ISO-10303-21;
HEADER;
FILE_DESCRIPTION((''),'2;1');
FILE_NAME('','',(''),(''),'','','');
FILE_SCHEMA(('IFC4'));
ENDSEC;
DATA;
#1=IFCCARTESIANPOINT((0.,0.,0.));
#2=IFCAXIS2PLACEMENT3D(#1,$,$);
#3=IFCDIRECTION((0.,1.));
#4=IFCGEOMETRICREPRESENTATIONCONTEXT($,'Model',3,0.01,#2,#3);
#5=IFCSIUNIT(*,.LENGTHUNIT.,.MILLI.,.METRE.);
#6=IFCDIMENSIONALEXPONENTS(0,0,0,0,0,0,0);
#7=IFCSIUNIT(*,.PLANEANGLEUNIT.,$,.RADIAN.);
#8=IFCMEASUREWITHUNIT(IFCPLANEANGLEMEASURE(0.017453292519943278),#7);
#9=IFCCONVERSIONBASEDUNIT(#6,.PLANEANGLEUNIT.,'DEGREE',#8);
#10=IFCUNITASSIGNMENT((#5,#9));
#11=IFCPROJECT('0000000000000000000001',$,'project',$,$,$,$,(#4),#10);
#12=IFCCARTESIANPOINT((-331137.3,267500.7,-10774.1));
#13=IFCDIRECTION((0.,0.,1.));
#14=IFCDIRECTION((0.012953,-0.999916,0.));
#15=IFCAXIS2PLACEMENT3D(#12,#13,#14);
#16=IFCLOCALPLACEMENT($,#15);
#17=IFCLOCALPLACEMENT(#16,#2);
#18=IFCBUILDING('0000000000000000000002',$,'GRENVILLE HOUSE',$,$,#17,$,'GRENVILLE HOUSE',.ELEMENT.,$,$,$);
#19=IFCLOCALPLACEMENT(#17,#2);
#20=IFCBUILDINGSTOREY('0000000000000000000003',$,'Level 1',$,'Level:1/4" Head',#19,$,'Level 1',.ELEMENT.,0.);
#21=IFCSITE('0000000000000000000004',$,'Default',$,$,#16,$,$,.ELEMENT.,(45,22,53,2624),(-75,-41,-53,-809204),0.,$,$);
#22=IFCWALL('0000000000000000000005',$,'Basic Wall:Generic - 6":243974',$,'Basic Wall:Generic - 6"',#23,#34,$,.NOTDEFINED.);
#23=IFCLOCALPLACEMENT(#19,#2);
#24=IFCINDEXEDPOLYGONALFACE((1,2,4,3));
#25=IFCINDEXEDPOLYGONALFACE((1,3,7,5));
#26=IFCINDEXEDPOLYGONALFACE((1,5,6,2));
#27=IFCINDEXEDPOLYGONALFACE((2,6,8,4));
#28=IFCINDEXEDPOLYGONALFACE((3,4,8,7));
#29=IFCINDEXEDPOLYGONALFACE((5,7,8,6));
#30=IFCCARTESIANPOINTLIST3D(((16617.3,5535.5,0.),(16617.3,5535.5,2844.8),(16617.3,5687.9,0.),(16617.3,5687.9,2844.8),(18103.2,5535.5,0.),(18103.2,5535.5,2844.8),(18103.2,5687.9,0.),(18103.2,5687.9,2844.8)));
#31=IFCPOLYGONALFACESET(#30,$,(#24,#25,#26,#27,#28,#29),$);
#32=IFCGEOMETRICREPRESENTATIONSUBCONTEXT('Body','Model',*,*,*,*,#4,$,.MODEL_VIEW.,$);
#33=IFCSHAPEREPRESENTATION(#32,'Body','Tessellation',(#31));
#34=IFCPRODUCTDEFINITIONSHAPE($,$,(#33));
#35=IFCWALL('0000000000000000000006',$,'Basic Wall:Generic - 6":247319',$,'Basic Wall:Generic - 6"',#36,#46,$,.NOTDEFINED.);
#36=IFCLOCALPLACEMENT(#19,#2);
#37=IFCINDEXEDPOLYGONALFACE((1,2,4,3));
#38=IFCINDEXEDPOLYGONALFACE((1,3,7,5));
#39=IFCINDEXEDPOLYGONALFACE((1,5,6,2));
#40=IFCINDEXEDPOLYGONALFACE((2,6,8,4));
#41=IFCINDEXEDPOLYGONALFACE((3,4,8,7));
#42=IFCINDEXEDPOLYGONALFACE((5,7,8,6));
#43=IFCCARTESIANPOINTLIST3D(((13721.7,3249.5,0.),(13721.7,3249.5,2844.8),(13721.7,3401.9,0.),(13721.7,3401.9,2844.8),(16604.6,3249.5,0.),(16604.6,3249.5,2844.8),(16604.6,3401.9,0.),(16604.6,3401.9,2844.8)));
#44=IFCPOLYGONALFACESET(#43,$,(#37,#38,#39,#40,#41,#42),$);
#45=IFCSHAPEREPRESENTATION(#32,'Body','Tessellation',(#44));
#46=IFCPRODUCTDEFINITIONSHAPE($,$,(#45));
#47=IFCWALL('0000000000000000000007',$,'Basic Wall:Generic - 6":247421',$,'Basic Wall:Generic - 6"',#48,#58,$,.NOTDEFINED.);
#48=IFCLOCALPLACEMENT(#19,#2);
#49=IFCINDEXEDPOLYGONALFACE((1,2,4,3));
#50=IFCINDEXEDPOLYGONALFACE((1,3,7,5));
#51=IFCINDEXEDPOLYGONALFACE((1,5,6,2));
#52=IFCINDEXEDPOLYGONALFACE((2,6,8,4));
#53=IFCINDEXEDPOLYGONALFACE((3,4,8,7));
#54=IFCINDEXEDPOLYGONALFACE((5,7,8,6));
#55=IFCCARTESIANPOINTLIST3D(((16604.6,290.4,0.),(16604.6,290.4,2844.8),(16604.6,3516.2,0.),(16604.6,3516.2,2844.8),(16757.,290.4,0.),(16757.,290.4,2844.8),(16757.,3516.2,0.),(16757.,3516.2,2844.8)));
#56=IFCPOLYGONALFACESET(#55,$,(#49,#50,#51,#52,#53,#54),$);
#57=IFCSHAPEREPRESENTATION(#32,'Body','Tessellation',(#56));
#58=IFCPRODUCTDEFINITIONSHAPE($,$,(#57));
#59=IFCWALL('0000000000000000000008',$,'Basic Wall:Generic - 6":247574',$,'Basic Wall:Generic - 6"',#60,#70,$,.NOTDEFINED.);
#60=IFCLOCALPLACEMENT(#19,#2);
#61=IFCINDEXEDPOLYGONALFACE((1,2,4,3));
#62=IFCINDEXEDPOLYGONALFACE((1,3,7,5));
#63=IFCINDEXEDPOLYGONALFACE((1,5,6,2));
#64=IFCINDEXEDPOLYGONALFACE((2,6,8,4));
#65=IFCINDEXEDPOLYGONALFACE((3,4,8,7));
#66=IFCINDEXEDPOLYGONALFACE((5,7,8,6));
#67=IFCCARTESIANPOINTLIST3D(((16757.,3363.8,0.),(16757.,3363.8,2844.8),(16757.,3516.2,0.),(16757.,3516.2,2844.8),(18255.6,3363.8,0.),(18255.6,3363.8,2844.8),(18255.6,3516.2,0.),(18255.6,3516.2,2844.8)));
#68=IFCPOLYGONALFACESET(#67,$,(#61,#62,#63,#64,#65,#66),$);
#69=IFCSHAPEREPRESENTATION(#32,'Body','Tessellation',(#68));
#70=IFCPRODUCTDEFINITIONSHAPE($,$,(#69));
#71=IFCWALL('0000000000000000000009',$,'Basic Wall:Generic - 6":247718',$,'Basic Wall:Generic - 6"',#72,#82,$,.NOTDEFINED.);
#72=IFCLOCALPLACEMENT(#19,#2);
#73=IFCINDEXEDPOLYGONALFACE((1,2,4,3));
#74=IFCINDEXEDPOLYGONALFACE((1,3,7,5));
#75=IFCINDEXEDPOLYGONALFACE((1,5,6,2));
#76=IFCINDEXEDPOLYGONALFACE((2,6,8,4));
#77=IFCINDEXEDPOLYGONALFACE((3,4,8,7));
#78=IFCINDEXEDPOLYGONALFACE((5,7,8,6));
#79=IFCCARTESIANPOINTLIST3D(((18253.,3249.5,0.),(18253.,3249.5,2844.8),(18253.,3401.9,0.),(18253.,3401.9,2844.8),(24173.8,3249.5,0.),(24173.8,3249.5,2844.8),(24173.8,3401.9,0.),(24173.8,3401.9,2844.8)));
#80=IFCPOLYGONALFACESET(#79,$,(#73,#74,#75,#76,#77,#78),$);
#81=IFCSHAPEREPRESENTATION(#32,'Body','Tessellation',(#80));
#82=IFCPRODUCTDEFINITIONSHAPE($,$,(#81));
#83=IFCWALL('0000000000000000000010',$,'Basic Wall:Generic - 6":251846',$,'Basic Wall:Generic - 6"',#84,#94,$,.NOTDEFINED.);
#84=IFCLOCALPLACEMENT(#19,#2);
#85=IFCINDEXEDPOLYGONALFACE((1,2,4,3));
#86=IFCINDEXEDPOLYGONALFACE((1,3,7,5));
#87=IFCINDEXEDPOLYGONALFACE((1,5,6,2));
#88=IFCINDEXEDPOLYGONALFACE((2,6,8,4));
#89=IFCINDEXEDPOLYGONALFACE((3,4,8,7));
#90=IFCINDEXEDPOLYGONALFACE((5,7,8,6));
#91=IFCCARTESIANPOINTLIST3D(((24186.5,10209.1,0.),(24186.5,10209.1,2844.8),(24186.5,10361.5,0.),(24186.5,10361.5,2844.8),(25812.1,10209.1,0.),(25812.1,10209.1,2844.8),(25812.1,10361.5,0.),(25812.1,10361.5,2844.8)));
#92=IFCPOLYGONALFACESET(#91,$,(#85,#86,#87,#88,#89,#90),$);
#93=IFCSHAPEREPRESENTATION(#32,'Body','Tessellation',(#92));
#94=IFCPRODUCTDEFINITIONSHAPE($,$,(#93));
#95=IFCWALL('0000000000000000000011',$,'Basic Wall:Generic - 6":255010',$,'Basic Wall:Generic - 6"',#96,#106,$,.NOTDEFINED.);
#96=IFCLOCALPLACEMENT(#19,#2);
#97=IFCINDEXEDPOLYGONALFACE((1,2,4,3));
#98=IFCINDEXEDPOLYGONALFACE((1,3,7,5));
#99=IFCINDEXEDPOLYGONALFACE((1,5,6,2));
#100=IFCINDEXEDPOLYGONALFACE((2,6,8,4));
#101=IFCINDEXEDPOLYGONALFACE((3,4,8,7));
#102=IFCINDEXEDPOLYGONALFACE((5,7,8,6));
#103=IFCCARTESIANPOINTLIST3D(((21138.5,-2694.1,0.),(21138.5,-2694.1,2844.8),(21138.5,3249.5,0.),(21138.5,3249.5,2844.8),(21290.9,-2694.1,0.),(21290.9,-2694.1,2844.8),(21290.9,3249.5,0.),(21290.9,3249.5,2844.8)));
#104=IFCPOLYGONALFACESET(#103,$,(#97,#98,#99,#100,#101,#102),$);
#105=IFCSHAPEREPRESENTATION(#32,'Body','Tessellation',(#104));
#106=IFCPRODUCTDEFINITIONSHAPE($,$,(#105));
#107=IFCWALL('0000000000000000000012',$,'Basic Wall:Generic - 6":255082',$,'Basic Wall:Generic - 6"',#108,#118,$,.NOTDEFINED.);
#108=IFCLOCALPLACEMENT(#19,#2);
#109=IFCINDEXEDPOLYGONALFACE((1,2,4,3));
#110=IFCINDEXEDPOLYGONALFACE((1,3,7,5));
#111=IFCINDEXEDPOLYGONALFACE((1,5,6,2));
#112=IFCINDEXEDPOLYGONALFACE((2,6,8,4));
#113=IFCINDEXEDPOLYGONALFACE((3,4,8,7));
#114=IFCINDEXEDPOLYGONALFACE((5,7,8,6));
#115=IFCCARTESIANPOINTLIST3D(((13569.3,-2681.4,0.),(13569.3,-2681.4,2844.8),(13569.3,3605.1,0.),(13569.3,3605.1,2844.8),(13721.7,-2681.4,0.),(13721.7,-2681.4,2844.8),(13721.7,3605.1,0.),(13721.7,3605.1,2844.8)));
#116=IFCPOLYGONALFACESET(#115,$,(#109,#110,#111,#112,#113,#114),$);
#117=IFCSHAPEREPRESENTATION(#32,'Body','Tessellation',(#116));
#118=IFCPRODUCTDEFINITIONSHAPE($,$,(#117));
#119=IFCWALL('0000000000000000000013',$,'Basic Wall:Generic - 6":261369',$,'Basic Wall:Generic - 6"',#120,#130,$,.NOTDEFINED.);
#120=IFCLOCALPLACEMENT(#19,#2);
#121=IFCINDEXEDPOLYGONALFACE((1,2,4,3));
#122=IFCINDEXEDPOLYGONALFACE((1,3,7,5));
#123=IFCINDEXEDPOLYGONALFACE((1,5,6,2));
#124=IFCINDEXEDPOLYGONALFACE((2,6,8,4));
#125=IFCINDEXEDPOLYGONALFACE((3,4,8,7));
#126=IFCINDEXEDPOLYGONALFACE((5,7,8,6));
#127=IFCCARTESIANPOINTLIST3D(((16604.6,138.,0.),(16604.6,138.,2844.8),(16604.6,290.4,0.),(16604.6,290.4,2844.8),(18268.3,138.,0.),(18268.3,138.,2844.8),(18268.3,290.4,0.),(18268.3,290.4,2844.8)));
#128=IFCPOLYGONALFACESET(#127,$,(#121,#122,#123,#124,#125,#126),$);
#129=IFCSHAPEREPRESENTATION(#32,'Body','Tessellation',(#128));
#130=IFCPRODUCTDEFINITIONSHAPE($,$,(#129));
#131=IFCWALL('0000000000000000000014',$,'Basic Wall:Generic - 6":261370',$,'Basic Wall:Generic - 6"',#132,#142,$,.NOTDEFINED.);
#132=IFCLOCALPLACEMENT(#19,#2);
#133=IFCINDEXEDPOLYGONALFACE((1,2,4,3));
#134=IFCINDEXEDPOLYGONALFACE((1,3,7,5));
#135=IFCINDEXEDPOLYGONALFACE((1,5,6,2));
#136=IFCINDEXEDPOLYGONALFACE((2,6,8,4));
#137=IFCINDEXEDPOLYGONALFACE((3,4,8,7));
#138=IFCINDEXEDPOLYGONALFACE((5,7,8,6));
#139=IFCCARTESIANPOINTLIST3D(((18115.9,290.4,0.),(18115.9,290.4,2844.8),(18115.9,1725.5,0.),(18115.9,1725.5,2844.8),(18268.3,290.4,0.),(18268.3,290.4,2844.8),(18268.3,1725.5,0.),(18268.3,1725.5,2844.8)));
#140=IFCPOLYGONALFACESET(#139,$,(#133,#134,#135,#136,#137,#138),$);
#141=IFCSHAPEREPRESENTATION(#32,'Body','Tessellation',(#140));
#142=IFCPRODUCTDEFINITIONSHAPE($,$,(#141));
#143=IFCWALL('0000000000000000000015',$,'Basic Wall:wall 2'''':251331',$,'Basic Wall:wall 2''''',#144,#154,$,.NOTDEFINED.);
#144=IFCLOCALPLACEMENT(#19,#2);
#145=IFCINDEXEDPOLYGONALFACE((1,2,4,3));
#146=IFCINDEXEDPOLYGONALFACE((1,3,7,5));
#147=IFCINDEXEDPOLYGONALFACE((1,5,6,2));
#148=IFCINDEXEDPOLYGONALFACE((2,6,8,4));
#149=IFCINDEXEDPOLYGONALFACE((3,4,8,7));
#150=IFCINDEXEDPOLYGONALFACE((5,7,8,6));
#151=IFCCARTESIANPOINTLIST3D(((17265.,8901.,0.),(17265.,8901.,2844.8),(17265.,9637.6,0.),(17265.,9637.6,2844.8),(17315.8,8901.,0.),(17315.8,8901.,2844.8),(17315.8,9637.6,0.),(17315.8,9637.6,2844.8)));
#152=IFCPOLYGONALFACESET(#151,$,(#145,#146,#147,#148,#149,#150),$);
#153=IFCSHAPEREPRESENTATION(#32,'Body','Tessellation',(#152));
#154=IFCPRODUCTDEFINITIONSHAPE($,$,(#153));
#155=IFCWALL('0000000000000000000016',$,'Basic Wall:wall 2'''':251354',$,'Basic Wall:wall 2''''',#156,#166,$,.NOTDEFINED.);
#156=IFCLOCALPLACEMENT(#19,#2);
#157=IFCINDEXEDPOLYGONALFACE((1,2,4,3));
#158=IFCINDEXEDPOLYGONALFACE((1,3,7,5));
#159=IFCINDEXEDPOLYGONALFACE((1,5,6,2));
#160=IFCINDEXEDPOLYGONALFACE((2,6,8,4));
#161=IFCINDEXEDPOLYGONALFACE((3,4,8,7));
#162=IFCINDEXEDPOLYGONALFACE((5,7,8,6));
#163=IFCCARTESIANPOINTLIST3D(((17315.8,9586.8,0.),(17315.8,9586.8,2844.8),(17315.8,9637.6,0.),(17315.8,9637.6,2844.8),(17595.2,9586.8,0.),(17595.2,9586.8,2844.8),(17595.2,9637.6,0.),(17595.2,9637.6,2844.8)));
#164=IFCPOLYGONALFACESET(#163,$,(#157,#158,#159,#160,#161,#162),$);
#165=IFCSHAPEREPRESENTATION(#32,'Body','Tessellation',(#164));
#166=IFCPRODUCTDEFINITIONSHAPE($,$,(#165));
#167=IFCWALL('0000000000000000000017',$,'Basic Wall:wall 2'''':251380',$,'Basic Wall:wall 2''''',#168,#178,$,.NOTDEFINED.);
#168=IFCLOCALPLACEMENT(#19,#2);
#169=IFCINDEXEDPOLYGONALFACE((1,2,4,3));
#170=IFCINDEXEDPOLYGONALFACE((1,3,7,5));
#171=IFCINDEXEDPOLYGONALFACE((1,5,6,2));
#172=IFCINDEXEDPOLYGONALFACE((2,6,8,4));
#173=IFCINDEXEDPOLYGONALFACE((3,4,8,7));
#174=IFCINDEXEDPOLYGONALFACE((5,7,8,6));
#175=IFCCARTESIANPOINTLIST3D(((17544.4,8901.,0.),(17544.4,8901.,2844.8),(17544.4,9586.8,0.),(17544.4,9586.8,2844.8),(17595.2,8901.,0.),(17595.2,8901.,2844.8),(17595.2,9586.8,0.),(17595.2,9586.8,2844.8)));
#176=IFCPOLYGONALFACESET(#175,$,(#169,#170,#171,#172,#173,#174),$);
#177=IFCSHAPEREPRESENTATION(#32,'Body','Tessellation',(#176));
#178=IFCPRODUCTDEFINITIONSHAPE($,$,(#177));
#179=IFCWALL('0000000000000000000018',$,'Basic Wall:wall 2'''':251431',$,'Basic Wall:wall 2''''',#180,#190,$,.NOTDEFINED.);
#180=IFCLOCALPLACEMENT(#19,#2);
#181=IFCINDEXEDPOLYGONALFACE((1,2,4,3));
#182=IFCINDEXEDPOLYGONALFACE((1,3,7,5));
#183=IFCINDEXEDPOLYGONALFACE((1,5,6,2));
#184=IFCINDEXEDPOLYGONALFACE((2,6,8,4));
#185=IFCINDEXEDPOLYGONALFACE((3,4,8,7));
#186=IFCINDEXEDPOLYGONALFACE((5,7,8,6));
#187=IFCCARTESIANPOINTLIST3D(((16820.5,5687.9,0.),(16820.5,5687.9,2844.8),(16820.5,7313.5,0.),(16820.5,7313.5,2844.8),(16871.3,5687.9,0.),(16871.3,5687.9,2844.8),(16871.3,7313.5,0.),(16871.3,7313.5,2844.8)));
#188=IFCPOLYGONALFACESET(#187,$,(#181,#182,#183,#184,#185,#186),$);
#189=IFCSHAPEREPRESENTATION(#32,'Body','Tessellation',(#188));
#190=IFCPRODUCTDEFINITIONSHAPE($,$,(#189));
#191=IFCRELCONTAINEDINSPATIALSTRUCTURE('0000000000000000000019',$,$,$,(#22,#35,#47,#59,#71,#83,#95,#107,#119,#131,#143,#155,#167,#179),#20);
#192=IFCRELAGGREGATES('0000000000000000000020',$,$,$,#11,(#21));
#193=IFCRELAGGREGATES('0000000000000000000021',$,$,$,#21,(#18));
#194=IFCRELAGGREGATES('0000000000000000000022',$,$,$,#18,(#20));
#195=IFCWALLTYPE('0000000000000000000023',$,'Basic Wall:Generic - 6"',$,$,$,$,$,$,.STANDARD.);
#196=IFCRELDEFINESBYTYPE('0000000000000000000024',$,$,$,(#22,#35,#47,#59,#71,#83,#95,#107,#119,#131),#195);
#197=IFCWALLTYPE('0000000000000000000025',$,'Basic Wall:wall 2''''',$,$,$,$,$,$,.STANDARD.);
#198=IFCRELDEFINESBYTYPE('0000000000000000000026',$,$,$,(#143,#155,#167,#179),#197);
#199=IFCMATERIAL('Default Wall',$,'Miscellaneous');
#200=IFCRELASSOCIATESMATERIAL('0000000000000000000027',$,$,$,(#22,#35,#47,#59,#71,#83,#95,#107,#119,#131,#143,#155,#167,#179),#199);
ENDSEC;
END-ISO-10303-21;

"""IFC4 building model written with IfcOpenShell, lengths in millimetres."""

from ifc_helpers import new_model, entity, si_unit, converted_unit, direction, frame, origin, place, context, subcontext, project, spatial, indexed_curve, outline, extrude, material, type_object, element, save


model = new_model("IFC4")

# Units and contexts
model_context = context("Model", 3, precision=0.01, world=origin(), true_north=direction((0.0, 1.0)))
body_context = subcontext(model_context, "Body", "Model", "MODEL_VIEW")
ifc_project = project(units=[si_unit("LENGTHUNIT", "METRE", prefix="MILLI"), converted_unit("PLANEANGLEUNIT", "DEGREE", entity("IfcPlaneAngleMeasure", 0.017453292519943278), si_unit("PLANEANGLEUNIT", "RADIAN"), dimensions=[0, 0, 0, 0, 0, 0, 0])], contexts=[model_context])

# Site, building, storey
site_placement = place(None, frame((-331137.3, 267500.7, -10774.1), z_axis=(0.0, 0.0, 1.0), x_axis=(0.012953, -0.999916, 0.0)))
site = spatial("IfcSite", under=ifc_project, at=site_placement, Name="Default", CompositionType="ELEMENT", RefLatitude=(45, 22, 53, 2624), RefLongitude=(-75, -41, -53, -809204), RefElevation=0.0)
building_placement = place(site_placement, origin())
building = spatial("IfcBuilding", under=site, at=building_placement, Name="GRENVILLE HOUSE", LongName="GRENVILLE HOUSE", CompositionType="ELEMENT")
storey_placement = place(building_placement, origin())
storey = spatial("IfcBuildingStorey", under=building, at=storey_placement, Name="Level 1", ObjectType="Level:1/4\" Head", LongName="Level 1", CompositionType="ELEMENT", Elevation=0.0)

# Walls
ifc_material_1 = material(Name="Default Wall", Category="Miscellaneous")
wall_type_1 = type_object("IfcWallType", Name="Basic Wall:Generic - 6\"", PredefinedType="STANDARD")
wall_1_placement = place(storey_placement, frame((18103.2, 5611.7, 0.0), z_axis=(0.0, 0.0, 1.0), x_axis=(-1.0, 0.0, 0.0)))
element("IfcWall", 1, at=wall_1_placement, inside=storey, type_object=wall_type_1, material=ifc_material_1, Name="Basic Wall:Generic - 6\":243974", ObjectType="Basic Wall:Generic - 6\"", PredefinedType="NOTDEFINED", context=body_context, shape_type="SweptSolid", body=[
    extrude(outline(indexed_curve([(1485.9, 76.2), (0.0, 76.2), (0.0, -76.2), (1485.9, -76.2), (1485.9, 76.2)], self_intersect=False)), origin(), (0.0, 0.0, 1.0), 2844.8),
])
wall_2_placement = place(storey_placement, frame((16604.6, 3325.7, 0.0), z_axis=(0.0, 0.0, 1.0), x_axis=(-1.0, 0.0, 0.0)))
element("IfcWall", 2, at=wall_2_placement, inside=storey, type_object=wall_type_1, material=ifc_material_1, Name="Basic Wall:Generic - 6\":247319", ObjectType="Basic Wall:Generic - 6\"", PredefinedType="NOTDEFINED", context=body_context, shape_type="SweptSolid", body=[
    extrude(outline(indexed_curve([(2882.9, 76.2), (0.0, 76.2), (0.0, -76.2), (2882.9, -76.2), (2882.9, 76.2)], self_intersect=False)), origin(), (0.0, 0.0, 1.0), 2844.8),
])
wall_3_placement = place(storey_placement, frame((16680.8, 290.4, 0.0), z_axis=(0.0, 0.0, 1.0), x_axis=(0.0, 1.0, 0.0)))
element("IfcWall", 3, at=wall_3_placement, inside=storey, type_object=wall_type_1, material=ifc_material_1, Name="Basic Wall:Generic - 6\":247421", ObjectType="Basic Wall:Generic - 6\"", PredefinedType="NOTDEFINED", context=body_context, shape_type="SweptSolid", body=[
    extrude(outline(indexed_curve([(3225.8, 76.2), (0.0, 76.2), (0.0, -76.2), (3225.8, -76.2), (3225.8, 76.2)], self_intersect=False)), origin(), (0.0, 0.0, 1.0), 2844.8),
])
wall_4_placement = place(storey_placement, frame((18255.6, 3440.0, 0.0), z_axis=(0.0, 0.0, 1.0), x_axis=(-1.0, 0.0, 0.0)))
element("IfcWall", 4, at=wall_4_placement, inside=storey, type_object=wall_type_1, material=ifc_material_1, Name="Basic Wall:Generic - 6\":247574", ObjectType="Basic Wall:Generic - 6\"", PredefinedType="NOTDEFINED", context=body_context, shape_type="SweptSolid", body=[
    extrude(outline(indexed_curve([(1498.6, 76.2), (0.0, 76.2), (0.0, -76.2), (1498.6, -76.2), (1498.6, 76.2)], self_intersect=False)), origin(), (0.0, 0.0, 1.0), 2844.8),
])
wall_5_placement = place(storey_placement, frame((18253.0, 3325.7, 0.0)))
element("IfcWall", 5, at=wall_5_placement, inside=storey, type_object=wall_type_1, material=ifc_material_1, Name="Basic Wall:Generic - 6\":247718", ObjectType="Basic Wall:Generic - 6\"", PredefinedType="NOTDEFINED", context=body_context, shape_type="SweptSolid", body=[
    extrude(outline(indexed_curve([(5920.8, 76.2), (0.0, 76.2), (0.0, -76.2), (5920.8, -76.2), (5920.8, 76.2)], self_intersect=False)), origin(), (0.0, 0.0, 1.0), 2844.8),
])
wall_6_placement = place(storey_placement, frame((24186.5, 10285.3, 0.0)))
element("IfcWall", 6, at=wall_6_placement, inside=storey, type_object=wall_type_1, material=ifc_material_1, Name="Basic Wall:Generic - 6\":251846", ObjectType="Basic Wall:Generic - 6\"", PredefinedType="NOTDEFINED", context=body_context, shape_type="SweptSolid", body=[
    extrude(outline(indexed_curve([(1625.6, 76.2), (0.0, 76.2), (0.0, -76.2), (1625.6, -76.2), (1625.6, 76.2)], self_intersect=False)), origin(), (0.0, 0.0, 1.0), 2844.8),
])
wall_7_placement = place(storey_placement, frame((21214.7, 3249.5, 0.0), z_axis=(0.0, 0.0, 1.0), x_axis=(0.0, -1.0, 0.0)))
element("IfcWall", 7, at=wall_7_placement, inside=storey, type_object=wall_type_1, material=ifc_material_1, Name="Basic Wall:Generic - 6\":255010", ObjectType="Basic Wall:Generic - 6\"", PredefinedType="NOTDEFINED", context=body_context, shape_type="SweptSolid", body=[
    extrude(outline(indexed_curve([(5943.6, 76.2), (0.0, 76.2), (0.0, -76.2), (5943.6, -76.2), (5943.6, 76.2)], self_intersect=False)), origin(), (0.0, 0.0, 1.0), 2844.8),
])
wall_8_placement = place(storey_placement, frame((13645.5, 3605.1, 0.0), z_axis=(0.0, 0.0, 1.0), x_axis=(0.0, -1.0, 0.0)))
element("IfcWall", 8, at=wall_8_placement, inside=storey, type_object=wall_type_1, material=ifc_material_1, Name="Basic Wall:Generic - 6\":255082", ObjectType="Basic Wall:Generic - 6\"", PredefinedType="NOTDEFINED", context=body_context, shape_type="SweptSolid", body=[
    extrude(outline(indexed_curve([(6286.5, 76.2), (0.0, 76.2), (0.0, -76.2), (6286.5, -76.2), (6286.5, 76.2)], self_intersect=False)), origin(), (0.0, 0.0, 1.0), 2844.8),
])
wall_9_placement = place(storey_placement, frame((18268.3, 214.2, 0.0), z_axis=(0.0, 0.0, 1.0), x_axis=(-1.0, 0.0, 0.0)))
element("IfcWall", 9, at=wall_9_placement, inside=storey, type_object=wall_type_1, material=ifc_material_1, Name="Basic Wall:Generic - 6\":261369", ObjectType="Basic Wall:Generic - 6\"", PredefinedType="NOTDEFINED", context=body_context, shape_type="SweptSolid", body=[
    extrude(outline(indexed_curve([(1663.7, 76.2), (0.0, 76.2), (0.0, -76.2), (1663.7, -76.2), (1663.7, 76.2)], self_intersect=False)), origin(), (0.0, 0.0, 1.0), 2844.8),
])
wall_10_placement = place(storey_placement, frame((18192.1, 1725.5, 0.0), z_axis=(0.0, 0.0, 1.0), x_axis=(0.0, -1.0, 0.0)))
element("IfcWall", 10, at=wall_10_placement, inside=storey, type_object=wall_type_1, material=ifc_material_1, Name="Basic Wall:Generic - 6\":261370", ObjectType="Basic Wall:Generic - 6\"", PredefinedType="NOTDEFINED", context=body_context, shape_type="SweptSolid", body=[
    extrude(outline(indexed_curve([(1435.1, 76.2), (0.0, 76.2), (0.0, -76.2), (1435.1, -76.2), (1435.1, 76.2)], self_intersect=False)), origin(), (0.0, 0.0, 1.0), 2844.8),
])
wall_type_2 = type_object("IfcWallType", Name="Basic Wall:wall 2''", PredefinedType="STANDARD")
wall_11_placement = place(storey_placement, frame((17290.4, 8901.0, 0.0), z_axis=(0.0, 0.0, 1.0), x_axis=(0.0, 1.0, 0.0)))
element("IfcWall", 11, at=wall_11_placement, inside=storey, type_object=wall_type_2, material=ifc_material_1, Name="Basic Wall:wall 2'':251331", ObjectType="Basic Wall:wall 2''", PredefinedType="NOTDEFINED", context=body_context, shape_type="SweptSolid", body=[
    extrude(outline(indexed_curve([(736.6, 25.4), (0.0, 25.4), (0.0, -25.4), (736.6, -25.4), (736.6, 25.4)], self_intersect=False)), origin(), (0.0, 0.0, 1.0), 2844.8),
])
wall_12_placement = place(storey_placement, frame((17315.8, 9612.2, 0.0)))
element("IfcWall", 12, at=wall_12_placement, inside=storey, type_object=wall_type_2, material=ifc_material_1, Name="Basic Wall:wall 2'':251354", ObjectType="Basic Wall:wall 2''", PredefinedType="NOTDEFINED", context=body_context, shape_type="SweptSolid", body=[
    extrude(outline(indexed_curve([(279.4, 25.4), (0.0, 25.4), (0.0, -25.4), (279.4, -25.4), (279.4, 25.4)], self_intersect=False)), origin(), (0.0, 0.0, 1.0), 2844.8),
])
wall_13_placement = place(storey_placement, frame((17569.8, 9586.8, 0.0), z_axis=(0.0, 0.0, 1.0), x_axis=(0.0, -1.0, 0.0)))
element("IfcWall", 13, at=wall_13_placement, inside=storey, type_object=wall_type_2, material=ifc_material_1, Name="Basic Wall:wall 2'':251380", ObjectType="Basic Wall:wall 2''", PredefinedType="NOTDEFINED", context=body_context, shape_type="SweptSolid", body=[
    extrude(outline(indexed_curve([(685.8, 25.4), (0.0, 25.4), (0.0, -25.4), (685.8, -25.4), (685.8, 25.4)], self_intersect=False)), origin(), (0.0, 0.0, 1.0), 2844.8),
])
wall_14_placement = place(storey_placement, frame((16845.9, 5687.9, 0.0), z_axis=(0.0, 0.0, 1.0), x_axis=(0.0, 1.0, 0.0)))
element("IfcWall", 14, at=wall_14_placement, inside=storey, type_object=wall_type_2, material=ifc_material_1, Name="Basic Wall:wall 2'':251431", ObjectType="Basic Wall:wall 2''", PredefinedType="NOTDEFINED", context=body_context, shape_type="SweptSolid", body=[
    extrude(outline(indexed_curve([(1625.6, 25.4), (0.0, 25.4), (0.0, -25.4), (1625.6, -25.4), (1625.6, 25.4)], self_intersect=False)), origin(), (0.0, 0.0, 1.0), 2844.8),
])

save(model, "model.ifc")
